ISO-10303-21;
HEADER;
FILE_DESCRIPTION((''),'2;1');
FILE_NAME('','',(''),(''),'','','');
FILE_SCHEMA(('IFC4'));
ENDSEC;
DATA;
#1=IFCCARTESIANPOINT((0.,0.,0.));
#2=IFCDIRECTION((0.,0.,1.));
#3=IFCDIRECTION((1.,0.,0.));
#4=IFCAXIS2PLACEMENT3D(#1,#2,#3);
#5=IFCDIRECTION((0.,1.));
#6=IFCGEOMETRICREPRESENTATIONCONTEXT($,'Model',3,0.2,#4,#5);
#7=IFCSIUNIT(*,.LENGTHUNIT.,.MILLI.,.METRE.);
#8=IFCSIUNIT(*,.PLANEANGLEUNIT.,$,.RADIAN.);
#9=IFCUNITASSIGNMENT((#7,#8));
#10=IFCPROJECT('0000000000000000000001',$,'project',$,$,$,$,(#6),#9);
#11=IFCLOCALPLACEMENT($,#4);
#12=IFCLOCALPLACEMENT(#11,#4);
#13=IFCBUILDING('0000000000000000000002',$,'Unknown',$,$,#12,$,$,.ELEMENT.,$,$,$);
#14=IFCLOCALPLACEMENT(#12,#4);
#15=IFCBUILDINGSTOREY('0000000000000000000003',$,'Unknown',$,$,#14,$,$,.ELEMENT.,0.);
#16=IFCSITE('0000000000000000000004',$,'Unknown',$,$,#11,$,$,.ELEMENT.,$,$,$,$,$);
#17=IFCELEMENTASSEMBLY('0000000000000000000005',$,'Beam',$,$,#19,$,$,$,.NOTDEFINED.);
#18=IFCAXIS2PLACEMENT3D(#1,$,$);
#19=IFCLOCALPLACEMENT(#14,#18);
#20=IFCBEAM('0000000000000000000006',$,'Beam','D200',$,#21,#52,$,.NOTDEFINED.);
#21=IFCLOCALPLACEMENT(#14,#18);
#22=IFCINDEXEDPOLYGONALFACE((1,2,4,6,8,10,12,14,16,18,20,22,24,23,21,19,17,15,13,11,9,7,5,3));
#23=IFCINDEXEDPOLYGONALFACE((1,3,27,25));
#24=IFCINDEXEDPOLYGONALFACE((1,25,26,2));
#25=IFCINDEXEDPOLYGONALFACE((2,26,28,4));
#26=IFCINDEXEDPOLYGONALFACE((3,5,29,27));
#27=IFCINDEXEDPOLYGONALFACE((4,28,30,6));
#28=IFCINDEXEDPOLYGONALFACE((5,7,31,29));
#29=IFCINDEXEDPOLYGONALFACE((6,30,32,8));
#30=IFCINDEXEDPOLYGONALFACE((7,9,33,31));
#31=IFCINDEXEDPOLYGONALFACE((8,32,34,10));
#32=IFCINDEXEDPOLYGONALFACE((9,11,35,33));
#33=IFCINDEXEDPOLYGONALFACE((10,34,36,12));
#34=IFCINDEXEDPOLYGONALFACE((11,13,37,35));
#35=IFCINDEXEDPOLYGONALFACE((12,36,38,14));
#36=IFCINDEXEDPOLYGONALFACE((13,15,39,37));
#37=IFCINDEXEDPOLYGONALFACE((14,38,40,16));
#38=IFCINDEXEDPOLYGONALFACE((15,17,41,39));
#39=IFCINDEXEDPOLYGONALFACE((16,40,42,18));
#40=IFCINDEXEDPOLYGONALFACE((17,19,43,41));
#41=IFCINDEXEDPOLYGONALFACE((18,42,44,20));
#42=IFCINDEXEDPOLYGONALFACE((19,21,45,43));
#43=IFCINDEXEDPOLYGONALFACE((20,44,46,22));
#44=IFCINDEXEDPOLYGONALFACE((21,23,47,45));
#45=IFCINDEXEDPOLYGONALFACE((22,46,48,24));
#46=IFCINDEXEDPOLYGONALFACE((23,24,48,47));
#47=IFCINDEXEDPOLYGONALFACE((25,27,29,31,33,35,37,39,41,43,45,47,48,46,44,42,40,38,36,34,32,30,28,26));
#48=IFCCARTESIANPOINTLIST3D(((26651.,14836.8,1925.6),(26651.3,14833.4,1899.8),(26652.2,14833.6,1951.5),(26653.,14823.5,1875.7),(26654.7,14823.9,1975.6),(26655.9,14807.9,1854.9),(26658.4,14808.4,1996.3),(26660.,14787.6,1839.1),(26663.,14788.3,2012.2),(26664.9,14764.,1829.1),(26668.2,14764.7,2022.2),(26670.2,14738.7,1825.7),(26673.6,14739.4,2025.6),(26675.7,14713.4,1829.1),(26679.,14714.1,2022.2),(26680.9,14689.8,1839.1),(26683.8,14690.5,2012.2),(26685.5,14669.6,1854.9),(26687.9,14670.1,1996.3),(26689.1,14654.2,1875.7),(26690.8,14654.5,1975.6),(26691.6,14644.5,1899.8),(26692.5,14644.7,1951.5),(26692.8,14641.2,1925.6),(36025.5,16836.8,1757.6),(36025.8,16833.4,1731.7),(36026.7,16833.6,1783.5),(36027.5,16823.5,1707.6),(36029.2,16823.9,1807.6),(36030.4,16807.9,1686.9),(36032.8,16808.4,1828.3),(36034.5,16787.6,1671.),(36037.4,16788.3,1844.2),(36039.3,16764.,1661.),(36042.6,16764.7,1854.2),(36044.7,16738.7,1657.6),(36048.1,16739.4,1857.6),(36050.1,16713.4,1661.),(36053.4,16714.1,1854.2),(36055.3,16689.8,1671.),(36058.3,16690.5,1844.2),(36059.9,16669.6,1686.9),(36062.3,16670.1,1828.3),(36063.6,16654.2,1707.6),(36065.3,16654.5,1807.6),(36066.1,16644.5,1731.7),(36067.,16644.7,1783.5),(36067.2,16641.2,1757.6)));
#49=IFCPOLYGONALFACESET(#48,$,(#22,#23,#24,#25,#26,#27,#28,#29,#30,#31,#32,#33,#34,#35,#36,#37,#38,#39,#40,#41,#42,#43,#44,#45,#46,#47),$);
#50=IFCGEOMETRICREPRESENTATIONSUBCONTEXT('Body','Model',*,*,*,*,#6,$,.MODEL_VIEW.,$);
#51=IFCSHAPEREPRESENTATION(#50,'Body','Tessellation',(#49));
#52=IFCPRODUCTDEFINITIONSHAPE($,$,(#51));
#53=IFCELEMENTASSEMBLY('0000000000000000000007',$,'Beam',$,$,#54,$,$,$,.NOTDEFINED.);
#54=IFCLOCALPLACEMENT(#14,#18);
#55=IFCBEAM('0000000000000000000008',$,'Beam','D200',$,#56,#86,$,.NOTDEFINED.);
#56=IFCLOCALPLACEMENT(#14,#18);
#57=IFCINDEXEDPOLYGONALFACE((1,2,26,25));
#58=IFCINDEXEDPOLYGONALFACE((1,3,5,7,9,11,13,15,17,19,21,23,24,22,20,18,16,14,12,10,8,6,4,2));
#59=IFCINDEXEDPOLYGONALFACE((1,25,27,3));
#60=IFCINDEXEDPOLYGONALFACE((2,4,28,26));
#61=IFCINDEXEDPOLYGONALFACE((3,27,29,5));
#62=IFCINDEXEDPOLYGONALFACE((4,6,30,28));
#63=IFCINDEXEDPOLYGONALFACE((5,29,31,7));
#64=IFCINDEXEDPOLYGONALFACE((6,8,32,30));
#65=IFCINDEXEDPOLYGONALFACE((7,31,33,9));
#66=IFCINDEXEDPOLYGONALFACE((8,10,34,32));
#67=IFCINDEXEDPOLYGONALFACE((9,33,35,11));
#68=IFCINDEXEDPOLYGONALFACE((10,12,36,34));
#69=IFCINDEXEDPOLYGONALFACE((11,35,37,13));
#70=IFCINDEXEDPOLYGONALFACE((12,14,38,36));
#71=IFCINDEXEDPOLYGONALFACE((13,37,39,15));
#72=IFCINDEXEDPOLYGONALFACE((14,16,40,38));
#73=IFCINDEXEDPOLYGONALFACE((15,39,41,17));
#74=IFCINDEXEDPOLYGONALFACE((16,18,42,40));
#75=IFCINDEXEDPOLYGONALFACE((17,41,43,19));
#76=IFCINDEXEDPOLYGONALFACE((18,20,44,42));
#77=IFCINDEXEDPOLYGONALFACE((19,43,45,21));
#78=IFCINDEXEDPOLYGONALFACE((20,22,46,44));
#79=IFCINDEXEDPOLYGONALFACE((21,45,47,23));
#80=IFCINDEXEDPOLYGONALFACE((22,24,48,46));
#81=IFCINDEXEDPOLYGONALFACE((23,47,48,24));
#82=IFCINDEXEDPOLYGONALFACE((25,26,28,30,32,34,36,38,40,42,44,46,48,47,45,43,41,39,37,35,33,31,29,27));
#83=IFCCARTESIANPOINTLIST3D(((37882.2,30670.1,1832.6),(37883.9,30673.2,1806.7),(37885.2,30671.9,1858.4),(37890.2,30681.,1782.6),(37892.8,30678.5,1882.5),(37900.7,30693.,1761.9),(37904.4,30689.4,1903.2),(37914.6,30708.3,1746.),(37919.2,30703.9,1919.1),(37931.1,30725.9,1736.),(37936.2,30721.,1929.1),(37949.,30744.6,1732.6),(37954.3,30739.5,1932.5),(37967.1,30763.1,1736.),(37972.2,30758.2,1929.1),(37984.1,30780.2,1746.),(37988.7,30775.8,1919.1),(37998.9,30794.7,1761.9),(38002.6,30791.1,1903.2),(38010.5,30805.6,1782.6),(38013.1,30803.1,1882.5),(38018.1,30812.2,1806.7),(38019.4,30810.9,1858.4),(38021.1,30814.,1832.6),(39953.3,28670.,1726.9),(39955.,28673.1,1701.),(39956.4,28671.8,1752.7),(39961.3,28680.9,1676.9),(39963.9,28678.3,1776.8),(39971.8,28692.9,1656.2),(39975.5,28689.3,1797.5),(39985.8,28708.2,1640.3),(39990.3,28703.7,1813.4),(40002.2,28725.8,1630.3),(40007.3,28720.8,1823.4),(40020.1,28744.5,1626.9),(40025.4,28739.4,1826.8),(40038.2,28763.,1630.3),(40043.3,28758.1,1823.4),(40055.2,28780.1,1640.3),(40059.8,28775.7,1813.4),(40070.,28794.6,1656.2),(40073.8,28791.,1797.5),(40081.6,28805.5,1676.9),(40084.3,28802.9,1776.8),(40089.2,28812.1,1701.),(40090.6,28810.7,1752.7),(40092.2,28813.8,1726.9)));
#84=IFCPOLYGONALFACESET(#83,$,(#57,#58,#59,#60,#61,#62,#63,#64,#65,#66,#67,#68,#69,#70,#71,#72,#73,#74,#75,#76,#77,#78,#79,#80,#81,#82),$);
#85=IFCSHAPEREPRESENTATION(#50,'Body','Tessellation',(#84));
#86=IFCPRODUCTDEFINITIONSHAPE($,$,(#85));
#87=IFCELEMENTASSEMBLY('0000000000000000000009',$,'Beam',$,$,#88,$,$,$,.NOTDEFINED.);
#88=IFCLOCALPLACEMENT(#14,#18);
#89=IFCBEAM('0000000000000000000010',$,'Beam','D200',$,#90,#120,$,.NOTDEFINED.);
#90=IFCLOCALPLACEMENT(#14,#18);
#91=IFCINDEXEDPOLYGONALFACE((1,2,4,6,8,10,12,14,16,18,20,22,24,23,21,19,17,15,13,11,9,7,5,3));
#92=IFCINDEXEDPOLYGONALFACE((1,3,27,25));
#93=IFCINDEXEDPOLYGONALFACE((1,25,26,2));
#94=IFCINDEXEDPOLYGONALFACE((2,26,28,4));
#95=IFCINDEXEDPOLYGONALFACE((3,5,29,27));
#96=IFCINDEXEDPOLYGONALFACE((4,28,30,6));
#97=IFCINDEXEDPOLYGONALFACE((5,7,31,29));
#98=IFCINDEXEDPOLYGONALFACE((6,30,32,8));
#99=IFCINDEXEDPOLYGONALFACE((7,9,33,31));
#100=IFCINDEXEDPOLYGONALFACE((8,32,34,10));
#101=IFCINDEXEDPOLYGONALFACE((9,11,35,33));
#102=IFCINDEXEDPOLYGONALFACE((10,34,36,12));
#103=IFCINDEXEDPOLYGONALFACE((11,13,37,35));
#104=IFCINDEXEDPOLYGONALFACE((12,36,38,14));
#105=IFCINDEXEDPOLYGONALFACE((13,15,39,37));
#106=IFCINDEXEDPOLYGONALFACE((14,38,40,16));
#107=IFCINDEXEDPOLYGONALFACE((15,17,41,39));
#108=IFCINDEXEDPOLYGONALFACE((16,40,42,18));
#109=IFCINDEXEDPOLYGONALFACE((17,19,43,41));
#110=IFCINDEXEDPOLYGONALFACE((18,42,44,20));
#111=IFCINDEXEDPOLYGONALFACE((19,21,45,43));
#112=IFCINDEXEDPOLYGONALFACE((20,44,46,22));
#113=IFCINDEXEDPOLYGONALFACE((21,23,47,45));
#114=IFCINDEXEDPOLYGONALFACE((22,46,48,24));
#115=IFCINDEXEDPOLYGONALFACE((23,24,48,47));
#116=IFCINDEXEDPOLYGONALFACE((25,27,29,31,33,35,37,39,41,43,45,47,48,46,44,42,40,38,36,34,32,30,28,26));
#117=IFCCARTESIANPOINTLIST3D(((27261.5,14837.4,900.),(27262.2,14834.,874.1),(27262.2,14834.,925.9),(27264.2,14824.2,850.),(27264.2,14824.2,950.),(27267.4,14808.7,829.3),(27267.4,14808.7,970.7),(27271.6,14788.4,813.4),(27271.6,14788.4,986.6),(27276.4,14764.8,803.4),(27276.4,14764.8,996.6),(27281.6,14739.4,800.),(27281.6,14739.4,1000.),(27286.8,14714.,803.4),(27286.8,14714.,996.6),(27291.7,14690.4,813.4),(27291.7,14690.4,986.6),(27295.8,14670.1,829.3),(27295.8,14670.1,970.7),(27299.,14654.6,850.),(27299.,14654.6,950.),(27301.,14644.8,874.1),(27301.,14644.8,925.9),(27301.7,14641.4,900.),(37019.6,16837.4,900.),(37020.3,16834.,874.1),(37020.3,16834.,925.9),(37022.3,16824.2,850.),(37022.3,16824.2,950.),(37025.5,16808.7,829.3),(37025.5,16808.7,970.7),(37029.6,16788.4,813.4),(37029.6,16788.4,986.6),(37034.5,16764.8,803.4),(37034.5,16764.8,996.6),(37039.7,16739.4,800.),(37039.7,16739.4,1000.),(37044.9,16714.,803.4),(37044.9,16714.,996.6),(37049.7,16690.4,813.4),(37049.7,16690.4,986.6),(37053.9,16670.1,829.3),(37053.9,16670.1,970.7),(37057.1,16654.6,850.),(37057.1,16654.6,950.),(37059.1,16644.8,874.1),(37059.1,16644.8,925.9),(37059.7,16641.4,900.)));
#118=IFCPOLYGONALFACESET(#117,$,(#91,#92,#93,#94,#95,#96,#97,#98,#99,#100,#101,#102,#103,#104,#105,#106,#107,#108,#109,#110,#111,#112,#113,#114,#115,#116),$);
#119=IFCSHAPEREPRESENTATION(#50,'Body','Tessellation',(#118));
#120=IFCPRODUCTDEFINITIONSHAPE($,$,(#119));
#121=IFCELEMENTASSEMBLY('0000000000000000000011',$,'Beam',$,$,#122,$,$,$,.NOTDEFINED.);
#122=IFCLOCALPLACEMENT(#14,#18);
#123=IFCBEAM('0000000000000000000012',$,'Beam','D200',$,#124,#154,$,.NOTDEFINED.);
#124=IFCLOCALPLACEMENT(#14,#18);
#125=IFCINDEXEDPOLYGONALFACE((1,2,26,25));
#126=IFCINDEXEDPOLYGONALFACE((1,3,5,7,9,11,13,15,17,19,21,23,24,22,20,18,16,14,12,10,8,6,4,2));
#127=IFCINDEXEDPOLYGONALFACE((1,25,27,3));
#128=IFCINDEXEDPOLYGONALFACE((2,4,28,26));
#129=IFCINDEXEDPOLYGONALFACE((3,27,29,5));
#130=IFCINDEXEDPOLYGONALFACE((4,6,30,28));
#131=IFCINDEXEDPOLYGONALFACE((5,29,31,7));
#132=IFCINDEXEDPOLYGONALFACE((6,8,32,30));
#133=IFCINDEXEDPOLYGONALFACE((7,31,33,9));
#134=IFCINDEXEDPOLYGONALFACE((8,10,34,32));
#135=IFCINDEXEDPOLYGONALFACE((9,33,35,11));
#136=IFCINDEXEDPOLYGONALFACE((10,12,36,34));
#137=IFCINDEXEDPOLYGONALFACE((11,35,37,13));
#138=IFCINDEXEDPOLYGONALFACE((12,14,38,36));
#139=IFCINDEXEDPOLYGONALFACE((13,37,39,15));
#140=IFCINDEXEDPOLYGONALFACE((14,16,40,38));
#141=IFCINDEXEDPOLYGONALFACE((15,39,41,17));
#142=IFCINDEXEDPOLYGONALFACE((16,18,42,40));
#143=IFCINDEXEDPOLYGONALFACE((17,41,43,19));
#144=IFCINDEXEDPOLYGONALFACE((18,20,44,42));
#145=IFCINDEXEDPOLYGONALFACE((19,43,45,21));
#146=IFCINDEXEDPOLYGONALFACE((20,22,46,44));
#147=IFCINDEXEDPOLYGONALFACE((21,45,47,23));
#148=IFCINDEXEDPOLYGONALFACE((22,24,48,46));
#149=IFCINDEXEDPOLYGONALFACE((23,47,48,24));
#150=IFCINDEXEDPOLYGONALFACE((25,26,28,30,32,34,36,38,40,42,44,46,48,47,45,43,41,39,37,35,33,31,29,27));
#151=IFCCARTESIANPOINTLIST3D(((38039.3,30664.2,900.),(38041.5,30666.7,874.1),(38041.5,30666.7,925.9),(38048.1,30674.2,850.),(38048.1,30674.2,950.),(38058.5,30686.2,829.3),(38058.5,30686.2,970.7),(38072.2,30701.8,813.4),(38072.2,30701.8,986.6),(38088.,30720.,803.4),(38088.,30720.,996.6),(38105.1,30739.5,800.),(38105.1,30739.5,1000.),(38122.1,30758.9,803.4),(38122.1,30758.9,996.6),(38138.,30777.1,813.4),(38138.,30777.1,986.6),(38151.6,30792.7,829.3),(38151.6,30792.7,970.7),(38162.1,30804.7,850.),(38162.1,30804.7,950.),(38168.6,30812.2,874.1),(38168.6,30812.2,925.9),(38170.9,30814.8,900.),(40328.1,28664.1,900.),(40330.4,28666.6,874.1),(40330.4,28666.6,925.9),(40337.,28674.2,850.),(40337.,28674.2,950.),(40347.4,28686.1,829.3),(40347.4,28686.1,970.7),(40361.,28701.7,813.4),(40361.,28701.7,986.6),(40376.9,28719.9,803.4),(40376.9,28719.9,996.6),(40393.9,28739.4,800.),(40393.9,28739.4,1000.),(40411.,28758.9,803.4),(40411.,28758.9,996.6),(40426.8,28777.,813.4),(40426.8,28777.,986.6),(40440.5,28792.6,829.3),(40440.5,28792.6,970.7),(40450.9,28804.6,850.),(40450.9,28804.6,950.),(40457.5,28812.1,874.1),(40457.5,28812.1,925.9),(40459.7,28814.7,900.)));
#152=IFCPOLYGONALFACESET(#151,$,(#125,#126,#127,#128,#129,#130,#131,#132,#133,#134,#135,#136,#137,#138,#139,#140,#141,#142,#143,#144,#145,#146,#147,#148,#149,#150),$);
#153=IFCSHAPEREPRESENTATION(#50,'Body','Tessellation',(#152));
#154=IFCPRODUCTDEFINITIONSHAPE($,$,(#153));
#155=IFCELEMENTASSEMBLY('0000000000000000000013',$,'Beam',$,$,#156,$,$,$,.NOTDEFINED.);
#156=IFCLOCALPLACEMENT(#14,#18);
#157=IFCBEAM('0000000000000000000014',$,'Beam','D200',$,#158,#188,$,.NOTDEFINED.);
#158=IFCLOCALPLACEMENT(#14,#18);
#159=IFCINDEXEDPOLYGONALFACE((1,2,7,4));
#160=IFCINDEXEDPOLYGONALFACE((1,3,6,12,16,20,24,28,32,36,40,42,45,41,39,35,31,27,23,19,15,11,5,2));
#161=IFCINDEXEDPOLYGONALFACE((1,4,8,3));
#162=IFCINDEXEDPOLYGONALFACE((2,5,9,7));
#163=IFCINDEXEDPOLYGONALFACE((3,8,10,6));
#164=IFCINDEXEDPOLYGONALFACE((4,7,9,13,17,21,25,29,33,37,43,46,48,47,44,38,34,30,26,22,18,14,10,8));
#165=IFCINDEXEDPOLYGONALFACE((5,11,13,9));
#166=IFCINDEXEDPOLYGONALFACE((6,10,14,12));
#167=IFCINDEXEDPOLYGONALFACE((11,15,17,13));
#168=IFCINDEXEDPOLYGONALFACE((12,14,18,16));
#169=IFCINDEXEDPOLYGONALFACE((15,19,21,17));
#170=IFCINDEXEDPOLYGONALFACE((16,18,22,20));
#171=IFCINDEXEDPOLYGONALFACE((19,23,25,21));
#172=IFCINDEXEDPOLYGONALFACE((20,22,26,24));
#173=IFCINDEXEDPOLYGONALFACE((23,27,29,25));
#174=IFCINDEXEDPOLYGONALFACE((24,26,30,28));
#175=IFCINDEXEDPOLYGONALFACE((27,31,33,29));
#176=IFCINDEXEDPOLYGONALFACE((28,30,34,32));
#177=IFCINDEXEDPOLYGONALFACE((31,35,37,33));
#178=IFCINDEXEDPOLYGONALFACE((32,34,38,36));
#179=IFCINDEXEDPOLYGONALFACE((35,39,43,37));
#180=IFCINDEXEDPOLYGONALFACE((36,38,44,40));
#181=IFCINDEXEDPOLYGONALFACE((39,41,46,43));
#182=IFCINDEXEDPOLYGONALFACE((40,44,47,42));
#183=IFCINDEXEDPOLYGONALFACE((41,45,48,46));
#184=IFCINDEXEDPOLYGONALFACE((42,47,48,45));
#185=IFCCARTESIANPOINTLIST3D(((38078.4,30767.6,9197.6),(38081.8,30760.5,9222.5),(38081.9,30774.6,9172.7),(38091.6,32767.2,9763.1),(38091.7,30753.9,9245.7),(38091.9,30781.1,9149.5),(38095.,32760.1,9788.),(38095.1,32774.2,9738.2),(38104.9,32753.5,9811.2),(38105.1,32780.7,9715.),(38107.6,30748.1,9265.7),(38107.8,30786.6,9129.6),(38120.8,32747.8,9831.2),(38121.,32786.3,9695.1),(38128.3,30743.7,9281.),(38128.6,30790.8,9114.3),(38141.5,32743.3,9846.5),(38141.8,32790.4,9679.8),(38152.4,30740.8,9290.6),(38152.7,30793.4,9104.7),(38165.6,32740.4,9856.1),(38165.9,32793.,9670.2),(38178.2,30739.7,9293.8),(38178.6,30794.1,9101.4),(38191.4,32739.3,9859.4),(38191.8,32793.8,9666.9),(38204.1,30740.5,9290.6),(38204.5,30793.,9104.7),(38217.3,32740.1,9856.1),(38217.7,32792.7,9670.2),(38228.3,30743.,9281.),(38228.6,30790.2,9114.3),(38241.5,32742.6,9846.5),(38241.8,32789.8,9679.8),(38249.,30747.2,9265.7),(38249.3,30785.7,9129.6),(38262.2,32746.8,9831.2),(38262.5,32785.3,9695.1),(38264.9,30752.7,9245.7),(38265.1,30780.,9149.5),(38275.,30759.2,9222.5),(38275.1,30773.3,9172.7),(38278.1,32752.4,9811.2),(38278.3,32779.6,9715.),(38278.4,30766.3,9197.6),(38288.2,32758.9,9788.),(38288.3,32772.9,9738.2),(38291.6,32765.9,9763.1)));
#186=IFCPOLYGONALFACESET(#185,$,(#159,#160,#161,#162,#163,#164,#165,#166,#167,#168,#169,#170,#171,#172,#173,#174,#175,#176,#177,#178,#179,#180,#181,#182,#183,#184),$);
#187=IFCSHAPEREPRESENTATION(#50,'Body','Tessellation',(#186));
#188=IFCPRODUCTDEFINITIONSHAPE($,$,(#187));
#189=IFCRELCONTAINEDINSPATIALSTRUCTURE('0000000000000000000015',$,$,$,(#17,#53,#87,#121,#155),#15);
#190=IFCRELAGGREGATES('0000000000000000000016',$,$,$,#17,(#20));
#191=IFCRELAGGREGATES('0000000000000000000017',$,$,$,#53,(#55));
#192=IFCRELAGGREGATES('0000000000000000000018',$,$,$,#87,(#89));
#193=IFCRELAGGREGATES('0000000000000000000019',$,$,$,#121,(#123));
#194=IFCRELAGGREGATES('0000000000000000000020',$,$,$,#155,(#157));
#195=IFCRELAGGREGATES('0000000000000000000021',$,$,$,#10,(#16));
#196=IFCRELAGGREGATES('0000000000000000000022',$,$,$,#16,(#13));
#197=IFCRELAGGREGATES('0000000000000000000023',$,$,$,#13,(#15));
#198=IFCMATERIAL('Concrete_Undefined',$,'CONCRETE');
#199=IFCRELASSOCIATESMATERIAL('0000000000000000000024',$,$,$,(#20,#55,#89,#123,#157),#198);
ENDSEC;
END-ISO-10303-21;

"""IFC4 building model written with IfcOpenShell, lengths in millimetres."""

from ifc_helpers import new_model, si_unit, direction, frame, origin_with_axes, place, context, subcontext, project, spatial, line, indexed_curve, outline, extrude, material, element, aggregate, save


model = new_model("IFC4")

# Units and contexts
model_context = context("Model", 3, precision=0.2, world=origin_with_axes(), true_north=direction((0.0, 1.0)))
body_context = subcontext(model_context, "Body", "Model", "MODEL_VIEW")
ifc_project = project(units=[si_unit("LENGTHUNIT", "METRE", prefix="MILLI"), si_unit("PLANEANGLEUNIT", "RADIAN")], contexts=[model_context])

# Site, building, storey
site_placement = place(None, origin_with_axes())
site = spatial("IfcSite", under=ifc_project, at=site_placement, Name="Unknown", CompositionType="ELEMENT")
building_placement = place(site_placement, origin_with_axes())
building = spatial("IfcBuilding", under=site, at=building_placement, Name="Unknown", CompositionType="ELEMENT")
storey_placement = place(building_placement, origin_with_axes())
storey = spatial("IfcBuildingStorey", under=building, at=storey_placement, Name="Unknown", CompositionType="ELEMENT", Elevation=0.0)

# Element assemblies, beams
ifc_material = material(Name="Concrete_Undefined", Category="CONCRETE")
assembly_1_placement = place(storey_placement, frame((36046.4, 16739.0, 1757.6), z_axis=(-0.20865, 0.97799, 0.0), x_axis=(-0.97784, -0.208618, 0.017531)))
assembly_1 = element("IfcElementAssembly", 1, at=assembly_1_placement, inside=storey, Name="Beam", PredefinedType="NOTDEFINED")
beam_1_placement = place(assembly_1_placement, origin_with_axes())
beam_1 = element("IfcBeam", 2, at=beam_1_placement, material=ifc_material, Name="Beam", Description="D200", PredefinedType="NOTDEFINED", context=body_context, shape_type="SolidModel", body=[
    extrude(outline(indexed_curve([(100.0, 0.0), (96.6, 25.9), (86.6, 50.0), (70.7, 70.7), (50.0, 86.6), (25.9, 96.6), (0.0, 100.0), (-25.9, 96.6), (-50.0, 86.6), (-70.7, 70.7), (-86.6, 50.0), (-96.6, 25.9), (-100.0, 0.0), (-96.6, -25.9), (-86.6, -50.0), (-70.7, -70.7), (-50.0, -86.6), (-25.9, -96.6), (0.0, -100.0), (25.9, -96.6), (50.0, -86.6), (70.7, -70.7), (86.6, -50.0), (96.6, -25.9)], segments=[line(1, 2, 3, 4, 5, 6, 7, 8, 9, 10, 11, 12, 13, 14, 15, 16, 17, 18, 19, 20, 21, 22, 23, 24, 1)])), frame((0.0, 0.0, 0.0), z_axis=(-1.0, 0.0, 0.0), x_axis=(0.0, 0.0, 1.0)), (0.0, 0.0, -1.0), 9586.9),
])
aggregate(assembly_1, [beam_1])
assembly_2_placement = place(storey_placement, frame((37951.7, 30742.0, 1832.6), z_axis=(-0.694672, -0.719327, 0.0), x_axis=(0.718843, -0.694204, -0.036685)))
assembly_2 = element("IfcElementAssembly", 3, at=assembly_2_placement, inside=storey, Name="Beam", PredefinedType="NOTDEFINED")
beam_2_placement = place(assembly_2_placement, origin_with_axes())
beam_2 = element("IfcBeam", 4, at=beam_2_placement, material=ifc_material, Name="Beam", Description="D200", PredefinedType="NOTDEFINED", context=body_context, shape_type="SolidModel", body=[
    extrude(outline(indexed_curve([(100.0, 0.0), (96.6, 25.9), (86.6, 50.0), (70.7, 70.7), (50.0, 86.6), (25.9, 96.6), (0.0, 100.0), (-25.9, 96.6), (-50.0, 86.6), (-70.7, 70.7), (-86.6, 50.0), (-96.6, 25.9), (-100.0, 0.0), (-96.6, -25.9), (-86.6, -50.0), (-70.7, -70.7), (-50.0, -86.6), (-25.9, -96.6), (0.0, -100.0), (25.9, -96.6), (50.0, -86.6), (70.7, -70.7), (86.6, -50.0), (96.6, -25.9)], segments=[line(1, 2, 3, 4, 5, 6, 7, 8, 9, 10, 11, 12, 13, 14, 15, 16, 17, 18, 19, 20, 21, 22, 23, 24, 1)])), frame((0.0, 0.0, 0.0), z_axis=(-1.0, 0.0, 0.0), x_axis=(0.0, 0.0, 1.0)), (0.0, 0.0, -1.0), 2881.2),
])
aggregate(assembly_2, [beam_2])
assembly_3_placement = place(storey_placement, frame((37039.7, 16739.4, 900.0), z_axis=(-0.200785, 0.979635, 0.0), x_axis=(-0.979635, -0.200785, 0.0)))
assembly_3 = element("IfcElementAssembly", 5, at=assembly_3_placement, inside=storey, Name="Beam", PredefinedType="NOTDEFINED")
beam_3_placement = place(assembly_3_placement, origin_with_axes())
beam_3 = element("IfcBeam", 6, at=beam_3_placement, material=ifc_material, Name="Beam", Description="D200", PredefinedType="NOTDEFINED", context=body_context, shape_type="SolidModel", body=[
    extrude(outline(indexed_curve([(100.0, 0.0), (96.6, 25.9), (86.6, 50.0), (70.7, 70.7), (50.0, 86.6), (25.9, 96.6), (0.0, 100.0), (-25.9, 96.6), (-50.0, 86.6), (-70.7, 70.7), (-86.6, 50.0), (-96.6, 25.9), (-100.0, 0.0), (-96.6, -25.9), (-86.6, -50.0), (-70.7, -70.7), (-50.0, -86.6), (-25.9, -96.6), (0.0, -100.0), (25.9, -96.6), (50.0, -86.6), (70.7, -70.7), (86.6, -50.0), (96.6, -25.9)], segments=[line(1, 2, 3, 4, 5, 6, 7, 8, 9, 10, 11, 12, 13, 14, 15, 16, 17, 18, 19, 20, 21, 22, 23, 24, 1)])), frame((0.0, 0.0, 0.0), z_axis=(-1.0, 0.0, 0.0), x_axis=(0.0, 0.0, 1.0)), (0.0, 0.0, -1.0), 9960.9),
])
aggregate(assembly_3, [beam_3])
assembly_4_placement = place(storey_placement, frame((38105.1, 30739.5, 900.0), z_axis=(-0.658006, -0.753013, 0.0), x_axis=(0.753013, -0.658006, 0.0)))
assembly_4 = element("IfcElementAssembly", 7, at=assembly_4_placement, inside=storey, Name="Beam", PredefinedType="NOTDEFINED")
beam_4_placement = place(assembly_4_placement, origin_with_axes())
beam_4 = element("IfcBeam", 8, at=beam_4_placement, material=ifc_material, Name="Beam", Description="D200", PredefinedType="NOTDEFINED", context=body_context, shape_type="SolidModel", body=[
    extrude(outline(indexed_curve([(100.0, 0.0), (96.6, 25.9), (86.6, 50.0), (70.7, 70.7), (50.0, 86.6), (25.9, 96.6), (0.0, 100.0), (-25.9, 96.6), (-50.0, 86.6), (-70.7, 70.7), (-86.6, 50.0), (-96.6, 25.9), (-100.0, 0.0), (-96.6, -25.9), (-86.6, -50.0), (-70.7, -70.7), (-50.0, -86.6), (-25.9, -96.6), (0.0, -100.0), (25.9, -96.6), (50.0, -86.6), (70.7, -70.7), (86.6, -50.0), (96.6, -25.9)], segments=[line(1, 2, 3, 4, 5, 6, 7, 8, 9, 10, 11, 12, 13, 14, 15, 16, 17, 18, 19, 20, 21, 22, 23, 24, 1)])), frame((0.0, 0.0, 0.0), z_axis=(-1.0, 0.0, 0.0), x_axis=(0.0, 0.0, 1.0)), (0.0, 0.0, -1.0), 3039.6),
])
aggregate(assembly_4, [beam_4])
assembly_5_placement = place(storey_placement, frame((38191.6, 32766.5, 9763.1), z_axis=(-0.999978, 0.006605, 0.0), x_axis=(-0.006356, -0.96224, -0.272128)))
assembly_5 = element("IfcElementAssembly", 9, at=assembly_5_placement, inside=storey, Name="Beam", PredefinedType="NOTDEFINED")
beam_5_placement = place(assembly_5_placement, origin_with_axes())
beam_5 = element("IfcBeam", 10, at=beam_5_placement, material=ifc_material, Name="Beam", Description="D200", PredefinedType="NOTDEFINED", context=body_context, shape_type="SolidModel", body=[
    extrude(outline(indexed_curve([(100.0, 0.0), (96.6, 25.9), (86.6, 50.0), (70.7, 70.7), (50.0, 86.6), (25.9, 96.6), (0.0, 100.0), (-25.9, 96.6), (-50.0, 86.6), (-70.7, 70.7), (-86.6, 50.0), (-96.6, 25.9), (-100.0, 0.0), (-96.6, -25.9), (-86.6, -50.0), (-70.7, -70.7), (-50.0, -86.6), (-25.9, -96.6), (0.0, -100.0), (25.9, -96.6), (50.0, -86.6), (70.7, -70.7), (86.6, -50.0), (96.6, -25.9)], segments=[line(1, 2, 3, 4, 5, 6, 7, 8, 9, 10, 11, 12, 13, 14, 15, 16, 17, 18, 19, 20, 21, 22, 23, 24, 1)])), frame((0.0, 0.0, 0.0), z_axis=(-1.0, 0.0, 0.0), x_axis=(0.0, 0.0, 1.0)), (0.0, 0.0, -1.0), 2078.1),
])
aggregate(assembly_5, [beam_5])

save(model, "model.ifc")
